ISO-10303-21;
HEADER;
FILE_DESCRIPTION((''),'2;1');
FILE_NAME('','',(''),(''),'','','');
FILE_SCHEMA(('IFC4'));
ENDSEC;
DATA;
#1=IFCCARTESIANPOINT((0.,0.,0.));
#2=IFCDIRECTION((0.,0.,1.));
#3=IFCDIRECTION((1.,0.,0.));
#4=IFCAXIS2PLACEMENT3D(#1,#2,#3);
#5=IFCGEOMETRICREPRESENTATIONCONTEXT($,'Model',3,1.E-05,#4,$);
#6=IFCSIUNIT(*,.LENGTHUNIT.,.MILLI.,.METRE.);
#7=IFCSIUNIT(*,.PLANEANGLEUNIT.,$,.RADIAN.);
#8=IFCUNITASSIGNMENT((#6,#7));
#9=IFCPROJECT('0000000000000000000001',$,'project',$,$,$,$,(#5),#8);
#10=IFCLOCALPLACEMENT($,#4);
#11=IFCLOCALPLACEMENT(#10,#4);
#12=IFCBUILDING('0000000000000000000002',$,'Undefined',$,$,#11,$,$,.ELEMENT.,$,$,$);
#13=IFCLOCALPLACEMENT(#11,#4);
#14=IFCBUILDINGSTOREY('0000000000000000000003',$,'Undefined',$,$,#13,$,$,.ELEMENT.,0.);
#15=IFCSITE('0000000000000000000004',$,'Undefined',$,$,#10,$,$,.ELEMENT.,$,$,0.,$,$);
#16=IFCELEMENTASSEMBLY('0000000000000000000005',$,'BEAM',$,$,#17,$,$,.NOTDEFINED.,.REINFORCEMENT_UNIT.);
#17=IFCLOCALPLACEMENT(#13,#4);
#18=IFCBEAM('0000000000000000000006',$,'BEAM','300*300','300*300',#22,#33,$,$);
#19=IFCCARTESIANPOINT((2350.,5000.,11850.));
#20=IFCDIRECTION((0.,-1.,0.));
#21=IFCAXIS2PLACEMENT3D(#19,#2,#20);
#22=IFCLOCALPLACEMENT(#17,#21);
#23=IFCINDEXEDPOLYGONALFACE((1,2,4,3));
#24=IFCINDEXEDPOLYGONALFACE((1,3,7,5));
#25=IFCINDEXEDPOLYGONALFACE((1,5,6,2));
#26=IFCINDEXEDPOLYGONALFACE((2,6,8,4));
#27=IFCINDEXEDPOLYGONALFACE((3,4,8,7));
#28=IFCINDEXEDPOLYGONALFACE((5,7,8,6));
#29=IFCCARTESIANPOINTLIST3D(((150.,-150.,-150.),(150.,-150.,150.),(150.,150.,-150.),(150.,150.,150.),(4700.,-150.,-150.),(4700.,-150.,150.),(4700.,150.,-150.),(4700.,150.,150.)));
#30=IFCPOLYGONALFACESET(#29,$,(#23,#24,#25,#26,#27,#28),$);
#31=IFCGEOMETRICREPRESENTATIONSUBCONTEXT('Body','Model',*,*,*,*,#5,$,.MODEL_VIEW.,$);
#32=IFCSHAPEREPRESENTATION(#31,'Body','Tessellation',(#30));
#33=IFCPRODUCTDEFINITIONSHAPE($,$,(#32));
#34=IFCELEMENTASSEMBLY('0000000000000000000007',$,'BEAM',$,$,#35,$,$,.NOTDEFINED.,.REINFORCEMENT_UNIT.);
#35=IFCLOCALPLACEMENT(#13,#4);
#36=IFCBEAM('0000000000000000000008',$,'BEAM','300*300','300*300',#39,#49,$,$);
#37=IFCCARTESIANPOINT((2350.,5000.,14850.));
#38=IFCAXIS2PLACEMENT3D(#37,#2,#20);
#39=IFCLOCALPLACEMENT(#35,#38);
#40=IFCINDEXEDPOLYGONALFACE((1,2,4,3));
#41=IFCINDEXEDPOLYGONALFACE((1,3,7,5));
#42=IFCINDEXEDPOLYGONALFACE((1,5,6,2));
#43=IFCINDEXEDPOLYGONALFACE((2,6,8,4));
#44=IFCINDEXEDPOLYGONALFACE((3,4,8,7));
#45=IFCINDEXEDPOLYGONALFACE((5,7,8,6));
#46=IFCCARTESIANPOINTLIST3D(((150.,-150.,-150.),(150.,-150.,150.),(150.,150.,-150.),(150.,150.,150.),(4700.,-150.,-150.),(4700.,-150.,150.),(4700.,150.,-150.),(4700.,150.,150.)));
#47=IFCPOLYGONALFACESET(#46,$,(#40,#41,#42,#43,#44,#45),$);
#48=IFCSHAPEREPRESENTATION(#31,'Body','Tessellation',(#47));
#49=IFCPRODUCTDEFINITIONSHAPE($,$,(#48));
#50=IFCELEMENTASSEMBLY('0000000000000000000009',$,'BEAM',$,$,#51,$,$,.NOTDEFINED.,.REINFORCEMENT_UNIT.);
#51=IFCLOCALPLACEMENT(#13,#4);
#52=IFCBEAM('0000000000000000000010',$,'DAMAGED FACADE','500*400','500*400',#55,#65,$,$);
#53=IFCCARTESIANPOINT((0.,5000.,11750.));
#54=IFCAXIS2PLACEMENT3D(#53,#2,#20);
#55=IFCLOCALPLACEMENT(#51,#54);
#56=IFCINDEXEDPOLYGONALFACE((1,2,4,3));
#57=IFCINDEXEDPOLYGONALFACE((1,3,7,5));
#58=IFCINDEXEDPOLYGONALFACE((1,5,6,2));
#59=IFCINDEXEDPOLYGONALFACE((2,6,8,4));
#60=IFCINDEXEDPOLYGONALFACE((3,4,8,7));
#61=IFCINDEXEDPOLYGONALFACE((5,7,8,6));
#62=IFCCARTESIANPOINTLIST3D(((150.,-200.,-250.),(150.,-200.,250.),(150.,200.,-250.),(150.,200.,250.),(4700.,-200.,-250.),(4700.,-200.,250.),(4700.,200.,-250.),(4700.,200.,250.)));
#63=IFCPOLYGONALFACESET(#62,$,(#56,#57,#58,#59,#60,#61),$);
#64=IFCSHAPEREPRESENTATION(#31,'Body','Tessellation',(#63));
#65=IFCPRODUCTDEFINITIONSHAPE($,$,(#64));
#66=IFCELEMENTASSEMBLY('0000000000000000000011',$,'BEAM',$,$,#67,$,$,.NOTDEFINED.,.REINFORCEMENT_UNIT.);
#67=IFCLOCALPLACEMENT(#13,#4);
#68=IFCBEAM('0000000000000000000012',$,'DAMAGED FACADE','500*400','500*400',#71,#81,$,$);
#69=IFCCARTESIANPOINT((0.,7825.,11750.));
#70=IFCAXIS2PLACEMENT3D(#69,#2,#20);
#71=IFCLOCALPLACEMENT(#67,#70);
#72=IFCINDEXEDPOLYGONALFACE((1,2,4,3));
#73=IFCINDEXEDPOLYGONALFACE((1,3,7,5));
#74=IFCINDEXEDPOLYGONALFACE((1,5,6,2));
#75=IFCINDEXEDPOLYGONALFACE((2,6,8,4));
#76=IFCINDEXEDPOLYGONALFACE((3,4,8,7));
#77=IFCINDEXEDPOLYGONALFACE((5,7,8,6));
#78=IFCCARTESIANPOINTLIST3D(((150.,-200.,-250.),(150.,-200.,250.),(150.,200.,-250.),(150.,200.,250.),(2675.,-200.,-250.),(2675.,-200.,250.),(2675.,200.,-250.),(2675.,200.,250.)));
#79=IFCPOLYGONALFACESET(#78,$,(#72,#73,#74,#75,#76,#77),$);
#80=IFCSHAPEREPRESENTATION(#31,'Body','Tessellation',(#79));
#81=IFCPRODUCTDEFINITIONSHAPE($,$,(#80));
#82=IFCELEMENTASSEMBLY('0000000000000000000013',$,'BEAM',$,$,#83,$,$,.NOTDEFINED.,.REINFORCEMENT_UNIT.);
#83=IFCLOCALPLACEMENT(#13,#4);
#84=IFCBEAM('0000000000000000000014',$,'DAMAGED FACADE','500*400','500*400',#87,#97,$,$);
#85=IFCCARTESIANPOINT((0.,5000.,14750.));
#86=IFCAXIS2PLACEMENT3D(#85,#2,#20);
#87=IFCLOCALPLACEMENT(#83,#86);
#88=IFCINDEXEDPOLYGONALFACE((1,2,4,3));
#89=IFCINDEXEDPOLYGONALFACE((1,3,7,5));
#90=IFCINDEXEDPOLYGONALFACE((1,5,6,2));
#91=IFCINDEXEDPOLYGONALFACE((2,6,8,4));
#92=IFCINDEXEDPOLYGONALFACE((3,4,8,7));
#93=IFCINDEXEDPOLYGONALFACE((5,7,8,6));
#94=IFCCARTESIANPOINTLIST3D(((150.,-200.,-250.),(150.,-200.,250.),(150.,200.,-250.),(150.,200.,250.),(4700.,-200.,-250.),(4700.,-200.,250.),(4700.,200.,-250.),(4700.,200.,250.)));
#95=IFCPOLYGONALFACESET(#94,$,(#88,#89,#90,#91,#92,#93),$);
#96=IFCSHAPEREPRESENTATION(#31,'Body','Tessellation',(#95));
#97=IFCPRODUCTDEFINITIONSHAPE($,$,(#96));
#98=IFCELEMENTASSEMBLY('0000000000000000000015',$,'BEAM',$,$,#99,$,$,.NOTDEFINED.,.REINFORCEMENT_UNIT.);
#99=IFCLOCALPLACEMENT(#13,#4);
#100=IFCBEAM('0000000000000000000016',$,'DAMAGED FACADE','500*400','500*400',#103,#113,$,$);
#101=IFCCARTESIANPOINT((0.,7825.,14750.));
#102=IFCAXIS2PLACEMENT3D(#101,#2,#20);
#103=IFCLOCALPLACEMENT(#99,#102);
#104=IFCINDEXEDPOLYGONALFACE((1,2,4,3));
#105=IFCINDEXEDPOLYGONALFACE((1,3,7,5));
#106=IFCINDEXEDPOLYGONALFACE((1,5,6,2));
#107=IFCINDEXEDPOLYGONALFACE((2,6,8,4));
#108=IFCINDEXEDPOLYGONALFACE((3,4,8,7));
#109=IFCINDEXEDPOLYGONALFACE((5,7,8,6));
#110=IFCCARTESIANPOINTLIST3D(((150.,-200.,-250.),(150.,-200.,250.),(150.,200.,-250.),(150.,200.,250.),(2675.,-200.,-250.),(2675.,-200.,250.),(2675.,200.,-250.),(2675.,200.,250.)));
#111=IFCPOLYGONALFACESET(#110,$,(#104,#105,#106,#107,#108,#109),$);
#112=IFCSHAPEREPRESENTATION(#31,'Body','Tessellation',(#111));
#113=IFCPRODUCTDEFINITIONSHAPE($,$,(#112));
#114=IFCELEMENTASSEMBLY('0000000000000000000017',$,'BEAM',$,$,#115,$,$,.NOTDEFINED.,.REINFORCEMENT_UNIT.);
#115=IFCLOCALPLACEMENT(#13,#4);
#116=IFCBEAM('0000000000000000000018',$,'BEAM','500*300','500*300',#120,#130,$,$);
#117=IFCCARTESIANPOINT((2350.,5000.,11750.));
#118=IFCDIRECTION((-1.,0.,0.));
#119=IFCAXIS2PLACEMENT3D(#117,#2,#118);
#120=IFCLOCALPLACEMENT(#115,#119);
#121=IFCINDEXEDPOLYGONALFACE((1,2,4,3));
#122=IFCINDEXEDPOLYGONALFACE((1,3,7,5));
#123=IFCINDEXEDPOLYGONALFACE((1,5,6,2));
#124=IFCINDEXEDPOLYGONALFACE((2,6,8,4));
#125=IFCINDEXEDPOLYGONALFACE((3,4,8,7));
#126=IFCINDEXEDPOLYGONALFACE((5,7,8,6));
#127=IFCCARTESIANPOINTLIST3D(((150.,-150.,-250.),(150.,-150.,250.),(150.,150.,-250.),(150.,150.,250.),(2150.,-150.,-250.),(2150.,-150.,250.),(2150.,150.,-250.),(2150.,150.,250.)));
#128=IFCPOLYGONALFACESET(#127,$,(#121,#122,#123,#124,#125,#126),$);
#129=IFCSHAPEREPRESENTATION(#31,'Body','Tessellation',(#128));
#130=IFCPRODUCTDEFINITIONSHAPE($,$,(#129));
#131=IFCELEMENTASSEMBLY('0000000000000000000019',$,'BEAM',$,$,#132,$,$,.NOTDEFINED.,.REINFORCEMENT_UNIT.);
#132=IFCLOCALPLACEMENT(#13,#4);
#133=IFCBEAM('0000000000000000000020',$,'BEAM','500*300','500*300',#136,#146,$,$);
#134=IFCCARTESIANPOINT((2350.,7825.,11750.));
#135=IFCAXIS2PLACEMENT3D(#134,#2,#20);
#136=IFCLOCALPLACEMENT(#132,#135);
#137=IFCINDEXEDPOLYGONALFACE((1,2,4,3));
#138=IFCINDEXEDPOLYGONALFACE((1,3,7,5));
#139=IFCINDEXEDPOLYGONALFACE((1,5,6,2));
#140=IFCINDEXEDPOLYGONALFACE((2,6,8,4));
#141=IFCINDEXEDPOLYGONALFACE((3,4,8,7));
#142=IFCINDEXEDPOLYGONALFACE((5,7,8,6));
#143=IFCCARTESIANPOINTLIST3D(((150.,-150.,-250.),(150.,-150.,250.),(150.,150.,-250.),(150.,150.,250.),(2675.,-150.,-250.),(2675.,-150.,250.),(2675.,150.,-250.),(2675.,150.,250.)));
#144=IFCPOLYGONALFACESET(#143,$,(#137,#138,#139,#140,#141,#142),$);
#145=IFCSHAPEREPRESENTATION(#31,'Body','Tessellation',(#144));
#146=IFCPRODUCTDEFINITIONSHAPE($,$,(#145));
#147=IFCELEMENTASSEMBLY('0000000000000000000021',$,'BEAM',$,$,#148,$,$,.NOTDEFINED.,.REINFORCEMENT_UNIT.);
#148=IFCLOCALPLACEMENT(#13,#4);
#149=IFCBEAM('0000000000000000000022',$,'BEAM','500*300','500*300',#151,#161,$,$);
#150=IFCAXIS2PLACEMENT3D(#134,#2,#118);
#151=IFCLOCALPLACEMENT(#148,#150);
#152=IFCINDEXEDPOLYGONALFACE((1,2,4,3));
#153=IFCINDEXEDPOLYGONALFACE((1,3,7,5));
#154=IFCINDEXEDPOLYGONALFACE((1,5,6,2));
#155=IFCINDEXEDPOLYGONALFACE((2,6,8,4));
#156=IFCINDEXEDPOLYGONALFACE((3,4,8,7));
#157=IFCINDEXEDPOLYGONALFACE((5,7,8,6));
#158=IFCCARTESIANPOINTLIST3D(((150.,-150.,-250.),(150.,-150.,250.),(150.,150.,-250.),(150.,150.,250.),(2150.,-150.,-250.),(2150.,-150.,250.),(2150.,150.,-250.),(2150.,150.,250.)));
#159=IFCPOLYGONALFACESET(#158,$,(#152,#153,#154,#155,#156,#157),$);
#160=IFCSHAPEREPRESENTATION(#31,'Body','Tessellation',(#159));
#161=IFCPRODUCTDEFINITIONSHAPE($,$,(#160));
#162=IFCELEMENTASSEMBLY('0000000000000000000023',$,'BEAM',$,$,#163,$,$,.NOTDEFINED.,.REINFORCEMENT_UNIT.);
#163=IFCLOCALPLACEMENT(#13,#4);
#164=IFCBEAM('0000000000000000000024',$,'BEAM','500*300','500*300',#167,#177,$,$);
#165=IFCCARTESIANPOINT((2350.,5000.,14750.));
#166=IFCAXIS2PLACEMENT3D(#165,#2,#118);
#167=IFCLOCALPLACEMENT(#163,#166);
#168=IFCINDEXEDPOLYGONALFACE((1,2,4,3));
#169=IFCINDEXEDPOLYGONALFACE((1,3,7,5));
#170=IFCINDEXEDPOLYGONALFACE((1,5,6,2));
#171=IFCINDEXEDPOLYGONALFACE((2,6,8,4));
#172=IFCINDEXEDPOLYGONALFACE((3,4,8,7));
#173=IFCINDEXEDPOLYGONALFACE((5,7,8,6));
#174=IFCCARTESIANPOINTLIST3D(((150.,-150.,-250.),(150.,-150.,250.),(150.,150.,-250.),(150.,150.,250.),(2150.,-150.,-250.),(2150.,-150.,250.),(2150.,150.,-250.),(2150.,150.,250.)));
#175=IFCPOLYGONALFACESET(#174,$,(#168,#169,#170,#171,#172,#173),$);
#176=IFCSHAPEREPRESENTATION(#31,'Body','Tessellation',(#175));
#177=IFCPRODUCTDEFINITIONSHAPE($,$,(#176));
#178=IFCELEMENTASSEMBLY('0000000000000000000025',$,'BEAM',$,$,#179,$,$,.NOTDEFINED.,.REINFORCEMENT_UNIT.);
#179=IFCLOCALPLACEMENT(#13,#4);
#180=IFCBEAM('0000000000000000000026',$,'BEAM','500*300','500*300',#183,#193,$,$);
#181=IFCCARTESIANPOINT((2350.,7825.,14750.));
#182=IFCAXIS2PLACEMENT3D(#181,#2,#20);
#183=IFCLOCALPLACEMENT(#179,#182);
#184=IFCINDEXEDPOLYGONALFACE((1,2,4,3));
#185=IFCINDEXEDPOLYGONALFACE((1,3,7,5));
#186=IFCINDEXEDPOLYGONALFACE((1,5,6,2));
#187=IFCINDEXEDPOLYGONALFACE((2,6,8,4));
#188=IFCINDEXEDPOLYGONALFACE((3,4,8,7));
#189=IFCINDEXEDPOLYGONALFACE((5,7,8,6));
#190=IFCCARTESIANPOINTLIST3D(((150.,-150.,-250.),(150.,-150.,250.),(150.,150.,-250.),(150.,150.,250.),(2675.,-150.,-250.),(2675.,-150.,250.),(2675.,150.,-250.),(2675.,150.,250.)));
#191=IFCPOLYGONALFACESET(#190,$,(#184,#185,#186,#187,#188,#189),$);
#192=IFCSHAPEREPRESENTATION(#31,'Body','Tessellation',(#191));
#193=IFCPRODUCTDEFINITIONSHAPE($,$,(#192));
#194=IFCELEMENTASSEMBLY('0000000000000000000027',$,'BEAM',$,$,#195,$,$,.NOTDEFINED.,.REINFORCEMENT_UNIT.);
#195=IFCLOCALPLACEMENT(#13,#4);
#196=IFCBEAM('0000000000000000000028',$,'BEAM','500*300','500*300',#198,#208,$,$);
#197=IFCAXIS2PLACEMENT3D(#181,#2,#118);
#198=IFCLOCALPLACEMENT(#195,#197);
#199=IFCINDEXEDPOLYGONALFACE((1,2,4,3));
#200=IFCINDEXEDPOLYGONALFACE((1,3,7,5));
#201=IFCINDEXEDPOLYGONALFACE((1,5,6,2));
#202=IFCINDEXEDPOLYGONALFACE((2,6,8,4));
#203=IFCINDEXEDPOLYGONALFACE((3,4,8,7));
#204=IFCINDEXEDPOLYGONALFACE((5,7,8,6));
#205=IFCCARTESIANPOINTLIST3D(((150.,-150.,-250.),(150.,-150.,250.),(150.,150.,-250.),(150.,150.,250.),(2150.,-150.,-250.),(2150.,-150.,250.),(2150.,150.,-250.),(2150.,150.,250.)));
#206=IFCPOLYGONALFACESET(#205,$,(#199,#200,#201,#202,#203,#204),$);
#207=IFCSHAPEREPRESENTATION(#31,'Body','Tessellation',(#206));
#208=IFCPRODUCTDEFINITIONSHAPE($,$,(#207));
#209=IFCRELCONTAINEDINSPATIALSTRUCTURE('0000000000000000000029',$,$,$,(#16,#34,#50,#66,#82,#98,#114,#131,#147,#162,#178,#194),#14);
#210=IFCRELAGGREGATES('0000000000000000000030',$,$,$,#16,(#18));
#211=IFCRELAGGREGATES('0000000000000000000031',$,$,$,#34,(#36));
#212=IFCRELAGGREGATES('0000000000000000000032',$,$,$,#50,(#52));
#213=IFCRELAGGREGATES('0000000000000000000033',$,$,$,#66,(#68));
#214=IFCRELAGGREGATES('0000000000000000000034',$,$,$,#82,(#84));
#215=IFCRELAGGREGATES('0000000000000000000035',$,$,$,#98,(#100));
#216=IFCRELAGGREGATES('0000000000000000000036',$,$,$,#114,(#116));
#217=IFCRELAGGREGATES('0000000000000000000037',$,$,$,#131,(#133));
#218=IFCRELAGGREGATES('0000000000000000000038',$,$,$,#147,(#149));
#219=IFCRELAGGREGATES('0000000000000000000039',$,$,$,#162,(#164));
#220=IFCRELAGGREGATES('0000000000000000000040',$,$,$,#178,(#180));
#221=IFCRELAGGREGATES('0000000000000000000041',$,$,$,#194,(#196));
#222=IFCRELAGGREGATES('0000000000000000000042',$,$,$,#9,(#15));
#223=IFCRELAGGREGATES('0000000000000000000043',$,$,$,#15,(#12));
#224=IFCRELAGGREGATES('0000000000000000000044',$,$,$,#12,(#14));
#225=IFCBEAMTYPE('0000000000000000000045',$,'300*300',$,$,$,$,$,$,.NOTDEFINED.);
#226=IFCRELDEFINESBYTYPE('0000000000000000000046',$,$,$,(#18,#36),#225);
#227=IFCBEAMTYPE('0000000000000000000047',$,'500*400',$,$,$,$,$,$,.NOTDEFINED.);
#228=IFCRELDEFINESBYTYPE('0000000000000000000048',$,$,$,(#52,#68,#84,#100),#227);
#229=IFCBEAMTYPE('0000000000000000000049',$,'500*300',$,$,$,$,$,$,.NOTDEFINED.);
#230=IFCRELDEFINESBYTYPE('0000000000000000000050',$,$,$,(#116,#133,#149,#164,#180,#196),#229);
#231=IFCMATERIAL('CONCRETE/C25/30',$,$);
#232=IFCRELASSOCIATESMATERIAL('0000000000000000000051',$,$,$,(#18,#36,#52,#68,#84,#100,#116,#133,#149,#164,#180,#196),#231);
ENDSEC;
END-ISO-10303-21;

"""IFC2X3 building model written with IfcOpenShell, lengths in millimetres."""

from ifc_helpers import new_model, si_unit, frame, origin_with_axes, origin_2d_with_axis, place, context, subcontext, project, spatial, rectangle, extrude, material, type_object, element, aggregate, save


model = new_model("IFC2X3")

# Units and contexts
model_context = context("Model", 3, precision=1e-05, world=origin_with_axes())
body_context = subcontext(model_context, "Body", "Model", "MODEL_VIEW")
ifc_project = project(units=[si_unit("LENGTHUNIT", "METRE", prefix="MILLI"), si_unit("PLANEANGLEUNIT", "RADIAN")], contexts=[model_context])

# Site, building, storey
site_placement = place(None, origin_with_axes())
site = spatial("IfcSite", under=ifc_project, at=site_placement, Name="Undefined", CompositionType="ELEMENT", RefElevation=0.0)
building_placement = place(site_placement, origin_with_axes())
building = spatial("IfcBuilding", under=site, at=building_placement, Name="Undefined", CompositionType="ELEMENT")
storey_placement = place(building_placement, origin_with_axes())
storey = spatial("IfcBuildingStorey", under=building, at=storey_placement, Name="Undefined", CompositionType="ELEMENT", Elevation=0.0)

# Shared definitions
ifc_material_1 = material(Name="CONCRETE/C25/30")

# Element assemblies, beams
assembly_1_placement = place(storey_placement, origin_with_axes())
assembly_1 = element("IfcElementAssembly", 1, at=assembly_1_placement, inside=storey, Name="BEAM", AssemblyPlace="NOTDEFINED", PredefinedType="REINFORCEMENT_UNIT")
beam_type_1 = type_object("IfcBeamType", Name="300*300", PredefinedType="NOTDEFINED")
beam_1_placement = place(assembly_1_placement, frame((2350.0, 5000.0, 11850.0), z_axis=(0.0, 0.0, 1.0), x_axis=(0.0, -1.0, 0.0)))
beam_1 = element("IfcBeam", 2, at=beam_1_placement, type_object=beam_type_1, material=ifc_material_1, Name="BEAM", Description="300*300", ObjectType="300*300", context=body_context, shape_type="SweptSolid", body=[
    extrude(rectangle(XDim=300.0, YDim=300.0, at=origin_2d_with_axis()), frame((4700.0, 0.0, 0.0), z_axis=(-1.0, 0.0, 0.0), x_axis=(0.0, -1.0, 0.0)), (0.0, 0.0, 1.0), 4550.0),
])
aggregate(assembly_1, [beam_1])
assembly_2_placement = place(storey_placement, origin_with_axes())
assembly_2 = element("IfcElementAssembly", 3, at=assembly_2_placement, inside=storey, Name="BEAM", AssemblyPlace="NOTDEFINED", PredefinedType="REINFORCEMENT_UNIT")
beam_2_placement = place(assembly_2_placement, frame((2350.0, 5000.0, 14850.0), z_axis=(0.0, 0.0, 1.0), x_axis=(0.0, -1.0, 0.0)))
beam_2 = element("IfcBeam", 4, at=beam_2_placement, type_object=beam_type_1, material=ifc_material_1, Name="BEAM", Description="300*300", ObjectType="300*300", context=body_context, shape_type="SweptSolid", body=[
    extrude(rectangle(XDim=300.0, YDim=300.0, at=origin_2d_with_axis()), frame((4700.0, 0.0, 0.0), z_axis=(-1.0, 0.0, 0.0), x_axis=(0.0, -1.0, 0.0)), (0.0, 0.0, 1.0), 4550.0),
])
aggregate(assembly_2, [beam_2])
assembly_3_placement = place(storey_placement, origin_with_axes())
assembly_3 = element("IfcElementAssembly", 5, at=assembly_3_placement, inside=storey, Name="BEAM", AssemblyPlace="NOTDEFINED", PredefinedType="REINFORCEMENT_UNIT")
beam_type_2 = type_object("IfcBeamType", Name="500*400", PredefinedType="NOTDEFINED")
beam_3_placement = place(assembly_3_placement, frame((0.0, 5000.0, 11750.0), z_axis=(0.0, 0.0, 1.0), x_axis=(0.0, -1.0, 0.0)))
beam_3 = element("IfcBeam", 6, at=beam_3_placement, type_object=beam_type_2, material=ifc_material_1, Name="DAMAGED FACADE", Description="500*400", ObjectType="500*400", context=body_context, shape_type="SweptSolid", body=[
    extrude(rectangle(XDim=400.0, YDim=500.0, at=origin_2d_with_axis()), frame((4700.0, 0.0, 0.0), z_axis=(-1.0, 0.0, 0.0), x_axis=(0.0, -1.0, 0.0)), (0.0, 0.0, 1.0), 4550.0),
])
aggregate(assembly_3, [beam_3])
assembly_4_placement = place(storey_placement, origin_with_axes())
assembly_4 = element("IfcElementAssembly", 7, at=assembly_4_placement, inside=storey, Name="BEAM", AssemblyPlace="NOTDEFINED", PredefinedType="REINFORCEMENT_UNIT")
beam_4_placement = place(assembly_4_placement, frame((0.0, 7825.0, 11750.0), z_axis=(0.0, 0.0, 1.0), x_axis=(0.0, -1.0, 0.0)))
beam_4 = element("IfcBeam", 8, at=beam_4_placement, type_object=beam_type_2, material=ifc_material_1, Name="DAMAGED FACADE", Description="500*400", ObjectType="500*400", context=body_context, shape_type="SweptSolid", body=[
    extrude(rectangle(XDim=400.0, YDim=500.0, at=origin_2d_with_axis()), frame((2675.0, 0.0, 0.0), z_axis=(-1.0, 0.0, 0.0), x_axis=(0.0, -1.0, 0.0)), (0.0, 0.0, 1.0), 2525.0),
])
aggregate(assembly_4, [beam_4])
assembly_5_placement = place(storey_placement, origin_with_axes())
assembly_5 = element("IfcElementAssembly", 9, at=assembly_5_placement, inside=storey, Name="BEAM", AssemblyPlace="NOTDEFINED", PredefinedType="REINFORCEMENT_UNIT")
beam_5_placement = place(assembly_5_placement, frame((0.0, 5000.0, 14750.0), z_axis=(0.0, 0.0, 1.0), x_axis=(0.0, -1.0, 0.0)))
beam_5 = element("IfcBeam", 10, at=beam_5_placement, type_object=beam_type_2, material=ifc_material_1, Name="DAMAGED FACADE", Description="500*400", ObjectType="500*400", context=body_context, shape_type="SweptSolid", body=[
    extrude(rectangle(XDim=400.0, YDim=500.0, at=origin_2d_with_axis()), frame((4700.0, 0.0, 0.0), z_axis=(-1.0, 0.0, 0.0), x_axis=(0.0, -1.0, 0.0)), (0.0, 0.0, 1.0), 4550.0),
])
aggregate(assembly_5, [beam_5])
assembly_6_placement = place(storey_placement, origin_with_axes())
assembly_6 = element("IfcElementAssembly", 11, at=assembly_6_placement, inside=storey, Name="BEAM", AssemblyPlace="NOTDEFINED", PredefinedType="REINFORCEMENT_UNIT")
beam_6_placement = place(assembly_6_placement, frame((0.0, 7825.0, 14750.0), z_axis=(0.0, 0.0, 1.0), x_axis=(0.0, -1.0, 0.0)))
beam_6 = element("IfcBeam", 12, at=beam_6_placement, type_object=beam_type_2, material=ifc_material_1, Name="DAMAGED FACADE", Description="500*400", ObjectType="500*400", context=body_context, shape_type="SweptSolid", body=[
    extrude(rectangle(XDim=400.0, YDim=500.0, at=origin_2d_with_axis()), frame((2675.0, 0.0, 0.0), z_axis=(-1.0, 0.0, 0.0), x_axis=(0.0, -1.0, 0.0)), (0.0, 0.0, 1.0), 2525.0),
])
aggregate(assembly_6, [beam_6])
assembly_7_placement = place(storey_placement, origin_with_axes())
assembly_7 = element("IfcElementAssembly", 13, at=assembly_7_placement, inside=storey, Name="BEAM", AssemblyPlace="NOTDEFINED", PredefinedType="REINFORCEMENT_UNIT")
beam_type_3 = type_object("IfcBeamType", Name="500*300", PredefinedType="NOTDEFINED")
beam_7_placement = place(assembly_7_placement, frame((2350.0, 5000.0, 11750.0), z_axis=(0.0, 0.0, 1.0), x_axis=(-1.0, 0.0, 0.0)))
beam_7 = element("IfcBeam", 14, at=beam_7_placement, type_object=beam_type_3, material=ifc_material_1, Name="BEAM", Description="500*300", ObjectType="500*300", context=body_context, shape_type="SweptSolid", body=[
    extrude(rectangle(XDim=300.0, YDim=500.0, at=origin_2d_with_axis()), frame((2150.0, 0.0, 0.0), z_axis=(-1.0, 0.0, 0.0), x_axis=(0.0, -1.0, 0.0)), (0.0, 0.0, 1.0), 2000.0),
])
aggregate(assembly_7, [beam_7])
assembly_8_placement = place(storey_placement, origin_with_axes())
assembly_8 = element("IfcElementAssembly", 15, at=assembly_8_placement, inside=storey, Name="BEAM", AssemblyPlace="NOTDEFINED", PredefinedType="REINFORCEMENT_UNIT")
beam_8_placement = place(assembly_8_placement, frame((2350.0, 7825.0, 11750.0), z_axis=(0.0, 0.0, 1.0), x_axis=(0.0, -1.0, 0.0)))
beam_8 = element("IfcBeam", 16, at=beam_8_placement, type_object=beam_type_3, material=ifc_material_1, Name="BEAM", Description="500*300", ObjectType="500*300", context=body_context, shape_type="SweptSolid", body=[
    extrude(rectangle(XDim=300.0, YDim=500.0, at=origin_2d_with_axis()), frame((2675.0, 0.0, 0.0), z_axis=(-1.0, 0.0, 0.0), x_axis=(0.0, -1.0, 0.0)), (0.0, 0.0, 1.0), 2525.0),
])
aggregate(assembly_8, [beam_8])
assembly_9_placement = place(storey_placement, origin_with_axes())
assembly_9 = element("IfcElementAssembly", 17, at=assembly_9_placement, inside=storey, Name="BEAM", AssemblyPlace="NOTDEFINED", PredefinedType="REINFORCEMENT_UNIT")
beam_9_placement = place(assembly_9_placement, frame((2350.0, 7825.0, 11750.0), z_axis=(0.0, 0.0, 1.0), x_axis=(-1.0, 0.0, 0.0)))
beam_9 = element("IfcBeam", 18, at=beam_9_placement, type_object=beam_type_3, material=ifc_material_1, Name="BEAM", Description="500*300", ObjectType="500*300", context=body_context, shape_type="SweptSolid", body=[
    extrude(rectangle(XDim=300.0, YDim=500.0, at=origin_2d_with_axis()), frame((2150.0, 0.0, 0.0), z_axis=(-1.0, 0.0, 0.0), x_axis=(0.0, -1.0, 0.0)), (0.0, 0.0, 1.0), 2000.0),
])
aggregate(assembly_9, [beam_9])
assembly_10_placement = place(storey_placement, origin_with_axes())
assembly_10 = element("IfcElementAssembly", 19, at=assembly_10_placement, inside=storey, Name="BEAM", AssemblyPlace="NOTDEFINED", PredefinedType="REINFORCEMENT_UNIT")
beam_10_placement = place(assembly_10_placement, frame((2350.0, 5000.0, 14750.0), z_axis=(0.0, 0.0, 1.0), x_axis=(-1.0, 0.0, 0.0)))
beam_10 = element("IfcBeam", 20, at=beam_10_placement, type_object=beam_type_3, material=ifc_material_1, Name="BEAM", Description="500*300", ObjectType="500*300", context=body_context, shape_type="SweptSolid", body=[
    extrude(rectangle(XDim=300.0, YDim=500.0, at=origin_2d_with_axis()), frame((2150.0, 0.0, 0.0), z_axis=(-1.0, 0.0, 0.0), x_axis=(0.0, -1.0, 0.0)), (0.0, 0.0, 1.0), 2000.0),
])
aggregate(assembly_10, [beam_10])
assembly_11_placement = place(storey_placement, origin_with_axes())
assembly_11 = element("IfcElementAssembly", 21, at=assembly_11_placement, inside=storey, Name="BEAM", AssemblyPlace="NOTDEFINED", PredefinedType="REINFORCEMENT_UNIT")
beam_11_placement = place(assembly_11_placement, frame((2350.0, 7825.0, 14750.0), z_axis=(0.0, 0.0, 1.0), x_axis=(0.0, -1.0, 0.0)))
beam_11 = element("IfcBeam", 22, at=beam_11_placement, type_object=beam_type_3, material=ifc_material_1, Name="BEAM", Description="500*300", ObjectType="500*300", context=body_context, shape_type="SweptSolid", body=[
    extrude(rectangle(XDim=300.0, YDim=500.0, at=origin_2d_with_axis()), frame((2675.0, 0.0, 0.0), z_axis=(-1.0, 0.0, 0.0), x_axis=(0.0, -1.0, 0.0)), (0.0, 0.0, 1.0), 2525.0),
])
aggregate(assembly_11, [beam_11])
assembly_12_placement = place(storey_placement, origin_with_axes())
assembly_12 = element("IfcElementAssembly", 23, at=assembly_12_placement, inside=storey, Name="BEAM", AssemblyPlace="NOTDEFINED", PredefinedType="REINFORCEMENT_UNIT")
beam_12_placement = place(assembly_12_placement, frame((2350.0, 7825.0, 14750.0), z_axis=(0.0, 0.0, 1.0), x_axis=(-1.0, 0.0, 0.0)))
beam_12 = element("IfcBeam", 24, at=beam_12_placement, type_object=beam_type_3, material=ifc_material_1, Name="BEAM", Description="500*300", ObjectType="500*300", context=body_context, shape_type="SweptSolid", body=[
    extrude(rectangle(XDim=300.0, YDim=500.0, at=origin_2d_with_axis()), frame((2150.0, 0.0, 0.0), z_axis=(-1.0, 0.0, 0.0), x_axis=(0.0, -1.0, 0.0)), (0.0, 0.0, 1.0), 2000.0),
])
aggregate(assembly_12, [beam_12])

save(model, "model.ifc")
